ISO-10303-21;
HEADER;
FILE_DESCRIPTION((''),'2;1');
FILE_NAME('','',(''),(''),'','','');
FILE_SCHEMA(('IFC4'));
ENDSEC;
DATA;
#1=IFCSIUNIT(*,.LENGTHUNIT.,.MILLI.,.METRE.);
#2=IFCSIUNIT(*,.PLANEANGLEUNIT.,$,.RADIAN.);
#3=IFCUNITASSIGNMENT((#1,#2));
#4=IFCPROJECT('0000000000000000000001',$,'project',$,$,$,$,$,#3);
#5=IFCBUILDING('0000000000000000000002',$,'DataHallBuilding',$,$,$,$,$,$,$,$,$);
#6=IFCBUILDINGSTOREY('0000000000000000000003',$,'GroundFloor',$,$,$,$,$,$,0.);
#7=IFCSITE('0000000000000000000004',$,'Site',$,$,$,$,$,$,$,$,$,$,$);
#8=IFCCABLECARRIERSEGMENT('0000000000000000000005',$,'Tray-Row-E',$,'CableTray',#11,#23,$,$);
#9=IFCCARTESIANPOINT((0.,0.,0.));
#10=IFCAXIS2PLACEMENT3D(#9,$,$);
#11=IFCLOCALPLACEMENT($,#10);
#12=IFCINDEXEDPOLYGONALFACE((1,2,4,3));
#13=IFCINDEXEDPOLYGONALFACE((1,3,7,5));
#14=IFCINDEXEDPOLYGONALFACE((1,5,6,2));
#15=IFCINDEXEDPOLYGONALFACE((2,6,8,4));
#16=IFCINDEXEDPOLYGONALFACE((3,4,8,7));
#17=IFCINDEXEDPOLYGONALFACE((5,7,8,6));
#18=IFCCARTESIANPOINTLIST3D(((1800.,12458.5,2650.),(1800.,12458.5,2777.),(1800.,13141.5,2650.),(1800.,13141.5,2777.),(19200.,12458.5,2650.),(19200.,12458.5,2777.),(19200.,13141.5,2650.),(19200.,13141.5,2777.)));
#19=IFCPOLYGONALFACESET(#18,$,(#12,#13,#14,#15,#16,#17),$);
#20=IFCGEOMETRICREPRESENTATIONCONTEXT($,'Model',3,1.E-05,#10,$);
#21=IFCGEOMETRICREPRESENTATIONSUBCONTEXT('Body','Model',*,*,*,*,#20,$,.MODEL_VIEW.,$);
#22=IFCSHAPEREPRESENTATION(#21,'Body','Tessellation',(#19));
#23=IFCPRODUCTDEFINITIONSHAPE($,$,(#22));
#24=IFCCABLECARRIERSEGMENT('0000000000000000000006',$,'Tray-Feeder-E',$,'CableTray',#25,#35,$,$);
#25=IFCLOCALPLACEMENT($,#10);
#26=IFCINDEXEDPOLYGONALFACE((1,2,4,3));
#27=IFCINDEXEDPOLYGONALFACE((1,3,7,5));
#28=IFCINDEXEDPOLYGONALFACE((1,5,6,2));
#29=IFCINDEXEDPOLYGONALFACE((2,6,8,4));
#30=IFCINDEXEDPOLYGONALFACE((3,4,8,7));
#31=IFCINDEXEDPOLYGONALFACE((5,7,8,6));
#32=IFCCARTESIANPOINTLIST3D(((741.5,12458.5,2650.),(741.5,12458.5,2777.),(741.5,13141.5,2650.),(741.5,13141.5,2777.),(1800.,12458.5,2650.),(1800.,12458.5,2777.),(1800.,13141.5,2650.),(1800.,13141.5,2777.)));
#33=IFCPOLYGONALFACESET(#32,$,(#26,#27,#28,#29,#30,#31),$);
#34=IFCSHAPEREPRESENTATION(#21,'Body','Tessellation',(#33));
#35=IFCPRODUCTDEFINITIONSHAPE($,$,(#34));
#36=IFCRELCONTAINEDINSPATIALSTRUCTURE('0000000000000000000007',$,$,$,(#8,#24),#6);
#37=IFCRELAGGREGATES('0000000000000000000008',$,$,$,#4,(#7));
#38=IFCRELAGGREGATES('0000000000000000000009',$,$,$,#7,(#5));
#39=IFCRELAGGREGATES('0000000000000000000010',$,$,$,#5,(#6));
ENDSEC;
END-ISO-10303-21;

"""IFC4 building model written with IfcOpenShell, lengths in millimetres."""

from ifc_helpers import new_model, si_unit, frame, origin, place, context, subcontext, project, spatial, rectangle, extrude, element, save


model = new_model("IFC4")

# Units and contexts
model_context = context("Model", 3, precision=1e-05, world=origin())
body_context = subcontext(model_context, "Body", "Model", "MODEL_VIEW")
ifc_project = project(units=[si_unit("LENGTHUNIT", "METRE", prefix="MILLI"), si_unit("PLANEANGLEUNIT", "RADIAN")])

# Site, building, storey
site = spatial("IfcSite", under=ifc_project, Name="Site")
building = spatial("IfcBuilding", under=site, Name="DataHallBuilding")
storey = spatial("IfcBuildingStorey", under=building, Name="GroundFloor", Elevation=0.0)

# Cable carrier segments
cable_carrier_segment_1_placement = place(None, origin())
element("IfcCableCarrierSegment", 1, at=cable_carrier_segment_1_placement, inside=storey, Name="Tray-Row-E", ObjectType="CableTray", context=body_context, shape_type="SweptSolid", body=[
    extrude(rectangle(XDim=17400.0, YDim=683.0), frame((10500.0, 12800.0, 2650.0), z_axis=(0.0, 0.0, 1.0), x_axis=(1.0, 0.0, 0.0)), (0.0, 0.0, 1.0), 127.0),
])
cable_carrier_segment_2_placement = place(None, origin())
element("IfcCableCarrierSegment", 2, at=cable_carrier_segment_2_placement, inside=storey, Name="Tray-Feeder-E", ObjectType="CableTray", context=body_context, shape_type="SweptSolid", body=[
    extrude(rectangle(XDim=1058.5, YDim=683.0), frame((1270.8, 12800.0, 2650.0), z_axis=(0.0, 0.0, 1.0), x_axis=(1.0, 0.0, 0.0)), (0.0, 0.0, 1.0), 127.0),
])

save(model, "model.ifc")
